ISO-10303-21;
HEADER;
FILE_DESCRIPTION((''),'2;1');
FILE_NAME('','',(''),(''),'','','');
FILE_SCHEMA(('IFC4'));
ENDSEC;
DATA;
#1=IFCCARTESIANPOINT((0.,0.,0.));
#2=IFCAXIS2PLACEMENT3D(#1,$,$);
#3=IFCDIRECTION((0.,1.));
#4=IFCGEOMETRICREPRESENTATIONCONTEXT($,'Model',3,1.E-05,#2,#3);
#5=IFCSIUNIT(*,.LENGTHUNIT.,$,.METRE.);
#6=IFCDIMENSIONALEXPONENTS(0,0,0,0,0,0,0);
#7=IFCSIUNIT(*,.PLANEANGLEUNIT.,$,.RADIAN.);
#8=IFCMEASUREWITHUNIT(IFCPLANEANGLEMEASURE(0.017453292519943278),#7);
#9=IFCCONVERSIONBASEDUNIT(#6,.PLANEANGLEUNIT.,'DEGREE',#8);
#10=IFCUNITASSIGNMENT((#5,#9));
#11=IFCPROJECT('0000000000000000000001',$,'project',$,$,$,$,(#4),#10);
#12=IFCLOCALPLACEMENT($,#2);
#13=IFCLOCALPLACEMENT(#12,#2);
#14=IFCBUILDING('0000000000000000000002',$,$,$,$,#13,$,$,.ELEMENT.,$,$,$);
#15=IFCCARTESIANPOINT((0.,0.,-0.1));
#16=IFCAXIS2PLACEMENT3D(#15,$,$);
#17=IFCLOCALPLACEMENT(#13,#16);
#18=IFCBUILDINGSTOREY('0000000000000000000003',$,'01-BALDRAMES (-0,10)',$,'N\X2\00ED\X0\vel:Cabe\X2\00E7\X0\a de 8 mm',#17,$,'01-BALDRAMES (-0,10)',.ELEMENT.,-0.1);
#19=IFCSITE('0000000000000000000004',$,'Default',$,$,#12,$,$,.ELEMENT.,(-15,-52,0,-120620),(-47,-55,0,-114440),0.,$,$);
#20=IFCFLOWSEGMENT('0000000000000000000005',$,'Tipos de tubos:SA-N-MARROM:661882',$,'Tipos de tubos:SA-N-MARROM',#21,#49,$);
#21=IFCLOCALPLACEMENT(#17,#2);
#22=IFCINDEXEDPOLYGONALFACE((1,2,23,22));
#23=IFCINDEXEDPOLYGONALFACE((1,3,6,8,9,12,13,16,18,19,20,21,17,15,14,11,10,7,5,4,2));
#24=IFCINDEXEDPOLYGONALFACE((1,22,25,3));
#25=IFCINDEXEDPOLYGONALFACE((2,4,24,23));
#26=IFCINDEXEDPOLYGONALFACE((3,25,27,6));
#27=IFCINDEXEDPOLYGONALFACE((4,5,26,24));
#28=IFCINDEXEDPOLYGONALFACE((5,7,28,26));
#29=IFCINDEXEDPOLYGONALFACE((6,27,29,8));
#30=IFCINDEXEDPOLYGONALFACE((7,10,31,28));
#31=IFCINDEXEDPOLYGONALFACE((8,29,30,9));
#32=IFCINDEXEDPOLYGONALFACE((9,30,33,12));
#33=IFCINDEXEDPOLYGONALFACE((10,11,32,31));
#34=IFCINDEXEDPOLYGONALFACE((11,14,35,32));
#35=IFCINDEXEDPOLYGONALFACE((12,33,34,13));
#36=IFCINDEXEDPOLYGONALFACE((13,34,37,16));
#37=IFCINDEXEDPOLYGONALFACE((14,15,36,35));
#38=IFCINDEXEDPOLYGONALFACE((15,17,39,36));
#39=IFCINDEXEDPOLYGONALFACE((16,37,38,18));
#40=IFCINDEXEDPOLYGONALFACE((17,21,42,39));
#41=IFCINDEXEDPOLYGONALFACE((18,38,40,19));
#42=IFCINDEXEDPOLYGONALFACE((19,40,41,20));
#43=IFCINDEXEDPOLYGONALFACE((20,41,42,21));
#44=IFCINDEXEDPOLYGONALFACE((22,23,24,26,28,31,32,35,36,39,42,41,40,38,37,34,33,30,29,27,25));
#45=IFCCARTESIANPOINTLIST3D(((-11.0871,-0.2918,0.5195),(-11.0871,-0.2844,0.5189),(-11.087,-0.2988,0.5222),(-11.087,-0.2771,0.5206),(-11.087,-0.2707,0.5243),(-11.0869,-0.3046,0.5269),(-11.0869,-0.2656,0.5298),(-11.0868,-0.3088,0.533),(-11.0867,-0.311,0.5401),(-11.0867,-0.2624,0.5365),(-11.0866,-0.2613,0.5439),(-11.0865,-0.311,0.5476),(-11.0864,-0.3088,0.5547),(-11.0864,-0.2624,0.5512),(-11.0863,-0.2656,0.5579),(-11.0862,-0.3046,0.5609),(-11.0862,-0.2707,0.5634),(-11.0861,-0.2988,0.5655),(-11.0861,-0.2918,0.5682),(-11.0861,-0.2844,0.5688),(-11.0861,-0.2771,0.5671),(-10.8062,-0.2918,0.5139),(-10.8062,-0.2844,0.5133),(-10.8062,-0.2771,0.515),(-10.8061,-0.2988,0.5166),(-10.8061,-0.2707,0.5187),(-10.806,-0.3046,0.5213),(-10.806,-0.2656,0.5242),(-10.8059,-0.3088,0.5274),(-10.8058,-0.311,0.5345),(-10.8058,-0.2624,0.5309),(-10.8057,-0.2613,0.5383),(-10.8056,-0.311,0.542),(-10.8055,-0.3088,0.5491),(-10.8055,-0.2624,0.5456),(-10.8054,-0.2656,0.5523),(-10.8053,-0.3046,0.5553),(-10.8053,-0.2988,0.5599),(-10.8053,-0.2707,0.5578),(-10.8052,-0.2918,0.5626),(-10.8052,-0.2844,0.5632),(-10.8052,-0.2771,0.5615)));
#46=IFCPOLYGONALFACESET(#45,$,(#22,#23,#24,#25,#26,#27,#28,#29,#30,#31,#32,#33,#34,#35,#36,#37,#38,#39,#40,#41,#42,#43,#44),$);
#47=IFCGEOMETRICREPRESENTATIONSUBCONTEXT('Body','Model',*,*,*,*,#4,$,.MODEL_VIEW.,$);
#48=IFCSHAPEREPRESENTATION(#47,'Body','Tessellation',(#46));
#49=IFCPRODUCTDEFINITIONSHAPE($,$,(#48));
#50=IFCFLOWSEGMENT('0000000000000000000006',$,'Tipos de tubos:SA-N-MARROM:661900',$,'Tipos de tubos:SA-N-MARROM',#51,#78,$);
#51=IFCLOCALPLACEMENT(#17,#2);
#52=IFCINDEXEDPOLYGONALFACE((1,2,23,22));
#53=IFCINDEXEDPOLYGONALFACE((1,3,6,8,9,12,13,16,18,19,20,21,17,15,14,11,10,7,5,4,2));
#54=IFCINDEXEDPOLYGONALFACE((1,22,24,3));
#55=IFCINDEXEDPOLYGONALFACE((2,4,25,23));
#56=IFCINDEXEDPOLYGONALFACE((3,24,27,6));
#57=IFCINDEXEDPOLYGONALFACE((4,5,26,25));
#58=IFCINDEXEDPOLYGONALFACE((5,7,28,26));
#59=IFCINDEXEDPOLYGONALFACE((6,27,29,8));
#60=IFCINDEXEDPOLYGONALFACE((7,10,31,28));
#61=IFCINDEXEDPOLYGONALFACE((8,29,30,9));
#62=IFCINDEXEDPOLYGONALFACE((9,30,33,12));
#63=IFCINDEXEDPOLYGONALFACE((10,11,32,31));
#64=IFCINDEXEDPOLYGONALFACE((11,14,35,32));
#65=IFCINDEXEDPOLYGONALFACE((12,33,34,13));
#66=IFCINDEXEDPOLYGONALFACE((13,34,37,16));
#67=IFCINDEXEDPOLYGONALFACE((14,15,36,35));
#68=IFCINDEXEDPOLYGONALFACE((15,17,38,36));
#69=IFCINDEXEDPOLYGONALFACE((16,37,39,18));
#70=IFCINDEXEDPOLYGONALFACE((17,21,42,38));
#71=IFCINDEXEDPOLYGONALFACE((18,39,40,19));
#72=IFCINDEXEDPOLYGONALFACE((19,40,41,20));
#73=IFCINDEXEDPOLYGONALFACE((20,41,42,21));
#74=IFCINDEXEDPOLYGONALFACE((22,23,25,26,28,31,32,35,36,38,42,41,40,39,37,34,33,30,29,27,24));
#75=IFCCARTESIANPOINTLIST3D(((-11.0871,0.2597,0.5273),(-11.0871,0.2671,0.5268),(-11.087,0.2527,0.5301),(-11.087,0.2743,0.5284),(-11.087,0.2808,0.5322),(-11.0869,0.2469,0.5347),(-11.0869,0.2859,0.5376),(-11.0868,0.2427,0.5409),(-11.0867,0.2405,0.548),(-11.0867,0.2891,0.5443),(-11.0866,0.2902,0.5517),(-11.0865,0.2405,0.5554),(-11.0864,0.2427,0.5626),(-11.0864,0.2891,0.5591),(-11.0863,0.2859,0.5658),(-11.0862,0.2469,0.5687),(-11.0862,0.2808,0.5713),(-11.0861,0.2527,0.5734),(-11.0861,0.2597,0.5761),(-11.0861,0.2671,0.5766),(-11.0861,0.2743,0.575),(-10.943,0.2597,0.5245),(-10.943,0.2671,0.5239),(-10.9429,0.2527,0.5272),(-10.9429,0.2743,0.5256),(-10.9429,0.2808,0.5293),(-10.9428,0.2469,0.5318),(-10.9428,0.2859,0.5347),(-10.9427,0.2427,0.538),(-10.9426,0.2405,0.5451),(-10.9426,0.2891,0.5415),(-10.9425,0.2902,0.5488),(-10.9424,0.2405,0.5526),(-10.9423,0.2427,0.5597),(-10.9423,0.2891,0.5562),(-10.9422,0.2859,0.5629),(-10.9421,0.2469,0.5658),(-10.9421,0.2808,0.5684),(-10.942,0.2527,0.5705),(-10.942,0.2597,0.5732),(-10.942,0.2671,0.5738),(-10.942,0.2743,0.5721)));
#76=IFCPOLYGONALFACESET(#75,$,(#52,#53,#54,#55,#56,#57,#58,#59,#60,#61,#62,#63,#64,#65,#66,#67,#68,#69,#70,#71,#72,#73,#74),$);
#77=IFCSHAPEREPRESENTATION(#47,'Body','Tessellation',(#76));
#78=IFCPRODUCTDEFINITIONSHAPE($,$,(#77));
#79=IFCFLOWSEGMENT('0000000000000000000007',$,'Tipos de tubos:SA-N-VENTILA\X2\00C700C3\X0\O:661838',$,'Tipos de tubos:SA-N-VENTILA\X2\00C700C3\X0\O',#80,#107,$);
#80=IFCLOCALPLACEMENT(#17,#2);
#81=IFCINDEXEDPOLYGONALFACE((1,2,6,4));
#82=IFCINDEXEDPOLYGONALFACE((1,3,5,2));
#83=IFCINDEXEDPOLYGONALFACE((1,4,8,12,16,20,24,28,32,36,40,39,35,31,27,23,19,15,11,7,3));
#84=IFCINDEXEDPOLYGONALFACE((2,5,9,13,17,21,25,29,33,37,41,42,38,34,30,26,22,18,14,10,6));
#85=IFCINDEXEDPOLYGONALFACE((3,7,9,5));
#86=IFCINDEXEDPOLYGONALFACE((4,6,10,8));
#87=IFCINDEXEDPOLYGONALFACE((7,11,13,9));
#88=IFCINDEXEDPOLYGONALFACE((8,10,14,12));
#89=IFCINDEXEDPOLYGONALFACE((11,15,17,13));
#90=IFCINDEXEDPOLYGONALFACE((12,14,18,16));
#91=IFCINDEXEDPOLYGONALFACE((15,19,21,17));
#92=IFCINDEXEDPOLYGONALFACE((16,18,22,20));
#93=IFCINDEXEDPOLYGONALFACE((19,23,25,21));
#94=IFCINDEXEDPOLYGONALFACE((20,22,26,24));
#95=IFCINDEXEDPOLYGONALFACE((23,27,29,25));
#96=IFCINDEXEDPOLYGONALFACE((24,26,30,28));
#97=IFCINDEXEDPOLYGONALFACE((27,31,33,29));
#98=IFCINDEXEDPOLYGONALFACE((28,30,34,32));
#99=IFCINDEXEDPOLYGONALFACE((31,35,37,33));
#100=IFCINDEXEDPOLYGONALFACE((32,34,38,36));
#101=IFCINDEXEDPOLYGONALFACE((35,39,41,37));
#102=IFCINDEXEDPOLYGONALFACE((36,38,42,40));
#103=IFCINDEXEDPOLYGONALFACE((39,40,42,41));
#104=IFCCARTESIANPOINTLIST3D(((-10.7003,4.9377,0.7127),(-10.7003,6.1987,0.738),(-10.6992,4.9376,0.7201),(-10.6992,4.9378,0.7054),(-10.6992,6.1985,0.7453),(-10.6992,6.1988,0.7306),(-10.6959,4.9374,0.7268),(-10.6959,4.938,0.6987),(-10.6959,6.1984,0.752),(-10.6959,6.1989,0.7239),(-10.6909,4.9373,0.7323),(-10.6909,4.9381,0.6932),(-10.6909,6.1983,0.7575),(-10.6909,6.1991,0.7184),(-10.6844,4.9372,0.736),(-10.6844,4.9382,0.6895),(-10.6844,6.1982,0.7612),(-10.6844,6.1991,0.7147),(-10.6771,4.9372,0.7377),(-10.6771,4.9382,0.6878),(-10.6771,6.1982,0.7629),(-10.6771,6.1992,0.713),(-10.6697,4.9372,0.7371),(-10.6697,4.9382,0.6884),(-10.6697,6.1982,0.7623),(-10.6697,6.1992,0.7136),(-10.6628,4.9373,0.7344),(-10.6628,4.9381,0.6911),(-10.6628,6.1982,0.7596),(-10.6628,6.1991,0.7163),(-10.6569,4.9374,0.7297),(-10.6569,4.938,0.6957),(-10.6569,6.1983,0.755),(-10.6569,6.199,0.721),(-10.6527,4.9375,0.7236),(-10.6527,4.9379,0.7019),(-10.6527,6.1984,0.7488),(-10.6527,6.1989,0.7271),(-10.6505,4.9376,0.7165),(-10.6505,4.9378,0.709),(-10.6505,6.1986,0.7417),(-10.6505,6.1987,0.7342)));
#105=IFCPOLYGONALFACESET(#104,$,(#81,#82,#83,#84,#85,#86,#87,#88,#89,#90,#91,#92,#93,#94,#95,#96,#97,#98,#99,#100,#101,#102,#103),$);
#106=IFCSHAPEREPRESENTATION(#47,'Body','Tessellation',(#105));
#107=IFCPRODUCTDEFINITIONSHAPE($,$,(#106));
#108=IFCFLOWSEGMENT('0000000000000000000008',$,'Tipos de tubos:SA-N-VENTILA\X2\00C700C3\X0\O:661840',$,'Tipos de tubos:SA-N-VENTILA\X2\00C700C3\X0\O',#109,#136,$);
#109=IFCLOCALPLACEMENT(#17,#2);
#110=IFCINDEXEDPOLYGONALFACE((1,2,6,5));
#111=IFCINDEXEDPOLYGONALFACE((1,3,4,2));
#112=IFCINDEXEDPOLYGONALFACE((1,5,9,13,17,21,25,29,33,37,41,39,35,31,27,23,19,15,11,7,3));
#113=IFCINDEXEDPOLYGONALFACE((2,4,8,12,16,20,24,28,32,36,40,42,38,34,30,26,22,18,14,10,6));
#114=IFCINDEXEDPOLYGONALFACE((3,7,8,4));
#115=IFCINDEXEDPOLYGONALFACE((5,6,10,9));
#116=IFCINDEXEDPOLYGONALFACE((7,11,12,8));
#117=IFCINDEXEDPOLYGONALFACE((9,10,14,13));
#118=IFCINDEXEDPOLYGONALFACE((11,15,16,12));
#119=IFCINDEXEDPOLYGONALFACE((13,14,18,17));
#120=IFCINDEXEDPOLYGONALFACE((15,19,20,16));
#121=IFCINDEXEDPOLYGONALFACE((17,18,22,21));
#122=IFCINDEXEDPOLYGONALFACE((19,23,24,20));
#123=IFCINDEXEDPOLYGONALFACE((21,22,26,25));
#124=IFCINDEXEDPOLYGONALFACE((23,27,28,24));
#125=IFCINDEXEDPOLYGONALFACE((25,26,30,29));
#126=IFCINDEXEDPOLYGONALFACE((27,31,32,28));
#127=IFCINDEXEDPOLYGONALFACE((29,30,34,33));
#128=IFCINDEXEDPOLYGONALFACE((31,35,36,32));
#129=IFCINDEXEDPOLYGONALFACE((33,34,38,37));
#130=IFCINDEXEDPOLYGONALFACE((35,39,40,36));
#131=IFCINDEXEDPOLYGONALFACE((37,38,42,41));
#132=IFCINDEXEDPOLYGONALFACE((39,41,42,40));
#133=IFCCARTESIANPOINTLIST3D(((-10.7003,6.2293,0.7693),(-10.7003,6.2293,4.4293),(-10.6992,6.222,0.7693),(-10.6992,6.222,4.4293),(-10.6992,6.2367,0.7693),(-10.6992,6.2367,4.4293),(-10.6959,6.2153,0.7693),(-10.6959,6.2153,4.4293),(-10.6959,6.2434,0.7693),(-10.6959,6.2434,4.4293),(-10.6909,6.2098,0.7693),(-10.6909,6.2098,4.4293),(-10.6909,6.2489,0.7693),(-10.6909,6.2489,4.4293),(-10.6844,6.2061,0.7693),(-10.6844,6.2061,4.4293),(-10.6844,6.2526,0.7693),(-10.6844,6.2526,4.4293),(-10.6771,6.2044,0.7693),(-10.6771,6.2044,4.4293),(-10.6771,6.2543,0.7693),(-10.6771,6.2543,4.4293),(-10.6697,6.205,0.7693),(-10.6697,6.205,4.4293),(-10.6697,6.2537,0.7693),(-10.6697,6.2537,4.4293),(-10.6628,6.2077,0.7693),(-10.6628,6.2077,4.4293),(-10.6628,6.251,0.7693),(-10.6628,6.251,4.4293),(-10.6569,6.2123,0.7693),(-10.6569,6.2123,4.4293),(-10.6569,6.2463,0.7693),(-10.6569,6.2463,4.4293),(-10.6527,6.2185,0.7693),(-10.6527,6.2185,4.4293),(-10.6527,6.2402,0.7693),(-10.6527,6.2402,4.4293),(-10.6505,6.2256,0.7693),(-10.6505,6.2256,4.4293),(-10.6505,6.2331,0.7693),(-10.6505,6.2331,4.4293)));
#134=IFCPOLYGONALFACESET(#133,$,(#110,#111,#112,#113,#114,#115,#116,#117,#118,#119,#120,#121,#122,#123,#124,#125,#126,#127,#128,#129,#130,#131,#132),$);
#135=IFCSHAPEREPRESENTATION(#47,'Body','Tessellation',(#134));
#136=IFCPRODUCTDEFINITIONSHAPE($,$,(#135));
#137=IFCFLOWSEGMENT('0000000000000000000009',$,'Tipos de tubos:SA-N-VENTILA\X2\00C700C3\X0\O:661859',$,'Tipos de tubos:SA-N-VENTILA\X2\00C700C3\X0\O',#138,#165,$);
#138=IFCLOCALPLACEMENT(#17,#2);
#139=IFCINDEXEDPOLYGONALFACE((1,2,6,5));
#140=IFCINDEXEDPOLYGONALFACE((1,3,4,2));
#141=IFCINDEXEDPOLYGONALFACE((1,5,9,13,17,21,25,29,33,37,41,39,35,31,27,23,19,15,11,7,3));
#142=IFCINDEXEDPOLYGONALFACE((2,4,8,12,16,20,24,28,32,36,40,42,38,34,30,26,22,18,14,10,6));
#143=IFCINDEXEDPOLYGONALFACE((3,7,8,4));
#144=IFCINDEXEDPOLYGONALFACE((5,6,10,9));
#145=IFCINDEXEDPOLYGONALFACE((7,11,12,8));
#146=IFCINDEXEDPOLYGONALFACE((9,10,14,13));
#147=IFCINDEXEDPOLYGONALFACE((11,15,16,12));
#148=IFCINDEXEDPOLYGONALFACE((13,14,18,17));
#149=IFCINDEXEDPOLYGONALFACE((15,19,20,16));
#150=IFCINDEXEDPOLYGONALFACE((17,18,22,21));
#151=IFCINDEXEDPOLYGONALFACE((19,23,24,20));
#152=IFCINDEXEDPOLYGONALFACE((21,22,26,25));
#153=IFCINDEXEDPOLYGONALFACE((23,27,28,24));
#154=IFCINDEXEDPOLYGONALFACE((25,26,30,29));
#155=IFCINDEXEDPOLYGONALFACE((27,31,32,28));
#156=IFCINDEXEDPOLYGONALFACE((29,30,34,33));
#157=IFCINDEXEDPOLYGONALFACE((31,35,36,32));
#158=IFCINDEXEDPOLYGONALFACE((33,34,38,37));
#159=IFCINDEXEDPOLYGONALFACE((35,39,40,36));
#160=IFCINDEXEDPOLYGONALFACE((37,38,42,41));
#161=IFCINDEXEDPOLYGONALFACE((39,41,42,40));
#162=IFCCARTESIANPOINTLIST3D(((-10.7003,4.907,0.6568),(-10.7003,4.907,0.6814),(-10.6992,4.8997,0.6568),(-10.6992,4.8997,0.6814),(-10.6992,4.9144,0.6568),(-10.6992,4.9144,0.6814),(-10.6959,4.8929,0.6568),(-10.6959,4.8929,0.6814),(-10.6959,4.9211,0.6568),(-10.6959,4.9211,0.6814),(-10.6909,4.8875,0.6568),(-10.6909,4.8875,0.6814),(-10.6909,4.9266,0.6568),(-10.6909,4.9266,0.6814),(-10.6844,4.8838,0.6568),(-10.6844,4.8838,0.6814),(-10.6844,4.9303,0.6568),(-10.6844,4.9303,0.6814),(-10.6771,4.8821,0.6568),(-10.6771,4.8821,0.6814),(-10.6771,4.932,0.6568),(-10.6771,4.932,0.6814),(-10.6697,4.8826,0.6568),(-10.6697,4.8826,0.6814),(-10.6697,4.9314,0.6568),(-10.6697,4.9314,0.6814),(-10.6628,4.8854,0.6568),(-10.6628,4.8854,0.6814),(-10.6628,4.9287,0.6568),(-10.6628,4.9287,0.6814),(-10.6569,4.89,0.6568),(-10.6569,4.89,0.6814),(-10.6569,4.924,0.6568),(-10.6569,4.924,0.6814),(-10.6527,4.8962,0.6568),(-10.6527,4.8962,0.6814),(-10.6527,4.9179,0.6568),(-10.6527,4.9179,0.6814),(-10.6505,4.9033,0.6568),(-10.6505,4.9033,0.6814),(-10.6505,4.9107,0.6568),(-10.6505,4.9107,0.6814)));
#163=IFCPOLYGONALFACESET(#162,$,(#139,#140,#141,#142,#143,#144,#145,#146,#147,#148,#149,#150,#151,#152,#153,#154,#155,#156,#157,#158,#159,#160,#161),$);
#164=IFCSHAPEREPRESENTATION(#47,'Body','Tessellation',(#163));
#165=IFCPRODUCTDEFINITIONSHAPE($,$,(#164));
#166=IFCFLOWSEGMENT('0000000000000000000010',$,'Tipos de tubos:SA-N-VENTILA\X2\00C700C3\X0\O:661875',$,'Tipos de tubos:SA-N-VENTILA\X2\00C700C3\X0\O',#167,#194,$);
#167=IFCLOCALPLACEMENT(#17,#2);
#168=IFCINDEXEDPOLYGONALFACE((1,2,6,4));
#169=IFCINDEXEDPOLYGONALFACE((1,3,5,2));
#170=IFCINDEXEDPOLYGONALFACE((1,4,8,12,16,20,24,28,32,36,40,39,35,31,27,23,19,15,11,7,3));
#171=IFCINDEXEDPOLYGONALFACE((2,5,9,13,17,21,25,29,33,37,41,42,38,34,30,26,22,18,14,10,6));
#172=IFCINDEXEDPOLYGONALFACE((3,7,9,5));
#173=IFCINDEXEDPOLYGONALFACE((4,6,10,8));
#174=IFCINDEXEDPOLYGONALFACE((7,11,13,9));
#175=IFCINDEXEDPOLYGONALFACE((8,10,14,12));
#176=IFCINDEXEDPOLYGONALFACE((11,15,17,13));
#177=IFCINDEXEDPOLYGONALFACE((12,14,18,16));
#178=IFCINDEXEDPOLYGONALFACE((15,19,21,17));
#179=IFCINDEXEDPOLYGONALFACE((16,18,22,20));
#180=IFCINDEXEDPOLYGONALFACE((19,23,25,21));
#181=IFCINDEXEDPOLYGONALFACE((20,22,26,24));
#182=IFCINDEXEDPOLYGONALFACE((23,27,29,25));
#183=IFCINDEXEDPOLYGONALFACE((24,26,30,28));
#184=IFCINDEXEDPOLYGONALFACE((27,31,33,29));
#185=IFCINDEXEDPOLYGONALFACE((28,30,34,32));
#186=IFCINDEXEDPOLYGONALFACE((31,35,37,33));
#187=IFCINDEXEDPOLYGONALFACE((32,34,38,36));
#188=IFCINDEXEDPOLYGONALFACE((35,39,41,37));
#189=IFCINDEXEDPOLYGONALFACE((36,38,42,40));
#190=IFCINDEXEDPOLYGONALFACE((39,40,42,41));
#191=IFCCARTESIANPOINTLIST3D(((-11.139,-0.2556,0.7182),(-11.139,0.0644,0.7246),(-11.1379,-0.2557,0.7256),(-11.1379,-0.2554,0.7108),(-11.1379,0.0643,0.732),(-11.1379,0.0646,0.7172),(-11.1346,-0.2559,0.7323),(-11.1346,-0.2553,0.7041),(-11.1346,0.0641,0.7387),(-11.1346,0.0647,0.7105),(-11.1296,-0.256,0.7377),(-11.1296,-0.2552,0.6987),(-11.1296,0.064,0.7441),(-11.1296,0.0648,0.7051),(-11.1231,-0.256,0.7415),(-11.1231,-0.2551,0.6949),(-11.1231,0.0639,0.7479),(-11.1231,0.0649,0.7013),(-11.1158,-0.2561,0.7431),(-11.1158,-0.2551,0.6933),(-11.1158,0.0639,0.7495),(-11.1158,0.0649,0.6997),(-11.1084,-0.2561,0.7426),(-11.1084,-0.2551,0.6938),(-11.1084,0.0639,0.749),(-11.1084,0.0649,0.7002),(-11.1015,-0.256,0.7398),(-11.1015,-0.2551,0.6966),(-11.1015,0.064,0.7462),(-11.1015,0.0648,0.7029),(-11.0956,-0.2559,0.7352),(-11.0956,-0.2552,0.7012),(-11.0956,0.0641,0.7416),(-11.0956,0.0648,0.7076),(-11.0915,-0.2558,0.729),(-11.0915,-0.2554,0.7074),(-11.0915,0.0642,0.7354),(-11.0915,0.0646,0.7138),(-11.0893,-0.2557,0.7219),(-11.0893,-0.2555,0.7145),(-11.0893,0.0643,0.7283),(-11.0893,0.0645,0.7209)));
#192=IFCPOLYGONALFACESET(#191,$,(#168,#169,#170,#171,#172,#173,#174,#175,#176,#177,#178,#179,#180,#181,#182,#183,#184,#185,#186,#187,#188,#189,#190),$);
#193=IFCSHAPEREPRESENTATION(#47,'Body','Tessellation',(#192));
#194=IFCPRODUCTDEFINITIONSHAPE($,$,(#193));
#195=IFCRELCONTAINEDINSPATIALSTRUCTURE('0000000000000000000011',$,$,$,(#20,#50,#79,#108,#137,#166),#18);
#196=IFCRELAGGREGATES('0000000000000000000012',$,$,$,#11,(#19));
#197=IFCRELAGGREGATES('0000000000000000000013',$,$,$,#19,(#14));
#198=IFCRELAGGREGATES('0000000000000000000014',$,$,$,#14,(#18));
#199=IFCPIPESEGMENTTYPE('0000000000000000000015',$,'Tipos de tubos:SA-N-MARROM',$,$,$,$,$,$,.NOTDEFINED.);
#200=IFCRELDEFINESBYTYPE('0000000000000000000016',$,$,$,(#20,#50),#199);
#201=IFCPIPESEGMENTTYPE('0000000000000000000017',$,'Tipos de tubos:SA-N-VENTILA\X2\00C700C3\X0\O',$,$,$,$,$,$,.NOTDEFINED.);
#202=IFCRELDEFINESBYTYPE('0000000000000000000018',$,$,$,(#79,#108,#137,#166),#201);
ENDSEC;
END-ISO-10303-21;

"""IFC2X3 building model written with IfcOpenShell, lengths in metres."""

from ifc_helpers import new_model, entity, si_unit, converted_unit, direction, frame, frame_2d, origin, origin_2d_with_axis, place, context, subcontext, project, spatial, circle, extrude, type_object, element, save


model = new_model("IFC2X3")

# Units and contexts
model_context = context("Model", 3, precision=1e-05, world=origin(), true_north=direction((0.0, 1.0)))
body_context = subcontext(model_context, "Body", "Model", "MODEL_VIEW")
ifc_project = project(units=[si_unit("LENGTHUNIT", "METRE"), converted_unit("PLANEANGLEUNIT", "DEGREE", entity("IfcPlaneAngleMeasure", 0.017453292519943278), si_unit("PLANEANGLEUNIT", "RADIAN"), dimensions=[0, 0, 0, 0, 0, 0, 0])], contexts=[model_context])

# Site, building, storey
site_placement = place(None, origin())
site = spatial("IfcSite", under=ifc_project, at=site_placement, Name="Default", CompositionType="ELEMENT", RefLatitude=(-15, -52, 0, -120620), RefLongitude=(-47, -55, 0, -114440), RefElevation=0.0)
building_placement = place(site_placement, origin())
building = spatial("IfcBuilding", under=site, at=building_placement, CompositionType="ELEMENT")
storey_placement = place(building_placement, frame((0.0, 0.0, -0.1)))
storey = spatial("IfcBuildingStorey", under=building, at=storey_placement, Name="01-BALDRAMES (-0,10)", ObjectType="Nível:Cabeça de 8 mm", LongName="01-BALDRAMES (-0,10)", CompositionType="ELEMENT", Elevation=-0.1)

# Flow segments
pipe_segment_type_1 = type_object("IfcPipeSegmentType", Name="Tipos de tubos:SA-N-MARROM", PredefinedType="NOTDEFINED")
flow_segment_1_placement = place(storey_placement, origin())
element("IfcFlowSegment", 1, at=flow_segment_1_placement, inside=storey, type_object=pipe_segment_type_1, Name="Tipos de tubos:SA-N-MARROM:661882", ObjectType="Tipos de tubos:SA-N-MARROM", context=body_context, shape_type="SweptSolid", body=[
    extrude(circle(Radius=0.025, at=origin_2d_with_axis()), frame((-10.8057, -0.2863, 0.5383), z_axis=(-0.9998, -0.000001, 0.019996), x_axis=(-0.000001, 1.0, 0.0)), (0.0, 0.0, 1.0), 0.2809),
])
flow_segment_2_placement = place(storey_placement, origin())
element("IfcFlowSegment", 2, at=flow_segment_2_placement, inside=storey, type_object=pipe_segment_type_1, Name="Tipos de tubos:SA-N-MARROM:661900", ObjectType="Tipos de tubos:SA-N-MARROM", context=body_context, shape_type="SweptSolid", body=[
    extrude(circle(Radius=0.025, at=frame_2d((0.0, 0.0), x_axis=(1.0, 0.0))), frame((-11.0866, 0.2652, 0.5517), z_axis=(0.9998, 0.000001, -0.019996), x_axis=(-0.000001, 1.0, 0.0)), (0.0, 0.0, 1.0), 0.1441),
])
pipe_segment_type_2 = type_object("IfcPipeSegmentType", Name="Tipos de tubos:SA-N-VENTILAÇÃO", PredefinedType="NOTDEFINED")
flow_segment_3_placement = place(storey_placement, origin())
element("IfcFlowSegment", 3, at=flow_segment_3_placement, inside=storey, type_object=pipe_segment_type_2, Name="Tipos de tubos:SA-N-VENTILAÇÃO:661838", ObjectType="Tipos de tubos:SA-N-VENTILAÇÃO", context=body_context, shape_type="SweptSolid", body=[
    extrude(circle(Radius=0.025, at=origin_2d_with_axis()), frame((-10.6753, 4.9377, 0.7127), z_axis=(-0.000001, 0.9998, 0.019996), x_axis=(-1.0, -0.000001, 0.0)), (0.0, 0.0, 1.0), 1.2612),
])
flow_segment_4_placement = place(storey_placement, origin())
element("IfcFlowSegment", 4, at=flow_segment_4_placement, inside=storey, type_object=pipe_segment_type_2, Name="Tipos de tubos:SA-N-VENTILAÇÃO:661840", ObjectType="Tipos de tubos:SA-N-VENTILAÇÃO", context=body_context, shape_type="SweptSolid", body=[
    extrude(circle(Radius=0.025, at=origin_2d_with_axis()), frame((-10.6753, 6.2293, 0.7693), z_axis=(0.0, 0.0, 1.0), x_axis=(-1.0, 0.0, 0.0)), (0.0, 0.0, 1.0), 3.6601),
])
flow_segment_5_placement = place(storey_placement, origin())
element("IfcFlowSegment", 5, at=flow_segment_5_placement, inside=storey, type_object=pipe_segment_type_2, Name="Tipos de tubos:SA-N-VENTILAÇÃO:661859", ObjectType="Tipos de tubos:SA-N-VENTILAÇÃO", context=body_context, shape_type="SweptSolid", body=[
    extrude(circle(Radius=0.025, at=origin_2d_with_axis()), frame((-10.6753, 4.907, 0.6568), z_axis=(0.0, 0.0, 1.0), x_axis=(-1.0, 0.0, 0.0)), (0.0, 0.0, 1.0), 0.0246),
])
flow_segment_6_placement = place(storey_placement, origin())
element("IfcFlowSegment", 6, at=flow_segment_6_placement, inside=storey, type_object=pipe_segment_type_2, Name="Tipos de tubos:SA-N-VENTILAÇÃO:661875", ObjectType="Tipos de tubos:SA-N-VENTILAÇÃO", context=body_context, shape_type="SweptSolid", body=[
    extrude(circle(Radius=0.025, at=frame_2d((0.0, 0.0), x_axis=(1.0, 0.0))), frame((-11.114, -0.2556, 0.7182), z_axis=(-0.000001, 0.9998, 0.019996), x_axis=(-1.0, -0.000001, 0.0)), (0.0, 0.0, 1.0), 0.3201),
])

save(model, "model.ifc")
